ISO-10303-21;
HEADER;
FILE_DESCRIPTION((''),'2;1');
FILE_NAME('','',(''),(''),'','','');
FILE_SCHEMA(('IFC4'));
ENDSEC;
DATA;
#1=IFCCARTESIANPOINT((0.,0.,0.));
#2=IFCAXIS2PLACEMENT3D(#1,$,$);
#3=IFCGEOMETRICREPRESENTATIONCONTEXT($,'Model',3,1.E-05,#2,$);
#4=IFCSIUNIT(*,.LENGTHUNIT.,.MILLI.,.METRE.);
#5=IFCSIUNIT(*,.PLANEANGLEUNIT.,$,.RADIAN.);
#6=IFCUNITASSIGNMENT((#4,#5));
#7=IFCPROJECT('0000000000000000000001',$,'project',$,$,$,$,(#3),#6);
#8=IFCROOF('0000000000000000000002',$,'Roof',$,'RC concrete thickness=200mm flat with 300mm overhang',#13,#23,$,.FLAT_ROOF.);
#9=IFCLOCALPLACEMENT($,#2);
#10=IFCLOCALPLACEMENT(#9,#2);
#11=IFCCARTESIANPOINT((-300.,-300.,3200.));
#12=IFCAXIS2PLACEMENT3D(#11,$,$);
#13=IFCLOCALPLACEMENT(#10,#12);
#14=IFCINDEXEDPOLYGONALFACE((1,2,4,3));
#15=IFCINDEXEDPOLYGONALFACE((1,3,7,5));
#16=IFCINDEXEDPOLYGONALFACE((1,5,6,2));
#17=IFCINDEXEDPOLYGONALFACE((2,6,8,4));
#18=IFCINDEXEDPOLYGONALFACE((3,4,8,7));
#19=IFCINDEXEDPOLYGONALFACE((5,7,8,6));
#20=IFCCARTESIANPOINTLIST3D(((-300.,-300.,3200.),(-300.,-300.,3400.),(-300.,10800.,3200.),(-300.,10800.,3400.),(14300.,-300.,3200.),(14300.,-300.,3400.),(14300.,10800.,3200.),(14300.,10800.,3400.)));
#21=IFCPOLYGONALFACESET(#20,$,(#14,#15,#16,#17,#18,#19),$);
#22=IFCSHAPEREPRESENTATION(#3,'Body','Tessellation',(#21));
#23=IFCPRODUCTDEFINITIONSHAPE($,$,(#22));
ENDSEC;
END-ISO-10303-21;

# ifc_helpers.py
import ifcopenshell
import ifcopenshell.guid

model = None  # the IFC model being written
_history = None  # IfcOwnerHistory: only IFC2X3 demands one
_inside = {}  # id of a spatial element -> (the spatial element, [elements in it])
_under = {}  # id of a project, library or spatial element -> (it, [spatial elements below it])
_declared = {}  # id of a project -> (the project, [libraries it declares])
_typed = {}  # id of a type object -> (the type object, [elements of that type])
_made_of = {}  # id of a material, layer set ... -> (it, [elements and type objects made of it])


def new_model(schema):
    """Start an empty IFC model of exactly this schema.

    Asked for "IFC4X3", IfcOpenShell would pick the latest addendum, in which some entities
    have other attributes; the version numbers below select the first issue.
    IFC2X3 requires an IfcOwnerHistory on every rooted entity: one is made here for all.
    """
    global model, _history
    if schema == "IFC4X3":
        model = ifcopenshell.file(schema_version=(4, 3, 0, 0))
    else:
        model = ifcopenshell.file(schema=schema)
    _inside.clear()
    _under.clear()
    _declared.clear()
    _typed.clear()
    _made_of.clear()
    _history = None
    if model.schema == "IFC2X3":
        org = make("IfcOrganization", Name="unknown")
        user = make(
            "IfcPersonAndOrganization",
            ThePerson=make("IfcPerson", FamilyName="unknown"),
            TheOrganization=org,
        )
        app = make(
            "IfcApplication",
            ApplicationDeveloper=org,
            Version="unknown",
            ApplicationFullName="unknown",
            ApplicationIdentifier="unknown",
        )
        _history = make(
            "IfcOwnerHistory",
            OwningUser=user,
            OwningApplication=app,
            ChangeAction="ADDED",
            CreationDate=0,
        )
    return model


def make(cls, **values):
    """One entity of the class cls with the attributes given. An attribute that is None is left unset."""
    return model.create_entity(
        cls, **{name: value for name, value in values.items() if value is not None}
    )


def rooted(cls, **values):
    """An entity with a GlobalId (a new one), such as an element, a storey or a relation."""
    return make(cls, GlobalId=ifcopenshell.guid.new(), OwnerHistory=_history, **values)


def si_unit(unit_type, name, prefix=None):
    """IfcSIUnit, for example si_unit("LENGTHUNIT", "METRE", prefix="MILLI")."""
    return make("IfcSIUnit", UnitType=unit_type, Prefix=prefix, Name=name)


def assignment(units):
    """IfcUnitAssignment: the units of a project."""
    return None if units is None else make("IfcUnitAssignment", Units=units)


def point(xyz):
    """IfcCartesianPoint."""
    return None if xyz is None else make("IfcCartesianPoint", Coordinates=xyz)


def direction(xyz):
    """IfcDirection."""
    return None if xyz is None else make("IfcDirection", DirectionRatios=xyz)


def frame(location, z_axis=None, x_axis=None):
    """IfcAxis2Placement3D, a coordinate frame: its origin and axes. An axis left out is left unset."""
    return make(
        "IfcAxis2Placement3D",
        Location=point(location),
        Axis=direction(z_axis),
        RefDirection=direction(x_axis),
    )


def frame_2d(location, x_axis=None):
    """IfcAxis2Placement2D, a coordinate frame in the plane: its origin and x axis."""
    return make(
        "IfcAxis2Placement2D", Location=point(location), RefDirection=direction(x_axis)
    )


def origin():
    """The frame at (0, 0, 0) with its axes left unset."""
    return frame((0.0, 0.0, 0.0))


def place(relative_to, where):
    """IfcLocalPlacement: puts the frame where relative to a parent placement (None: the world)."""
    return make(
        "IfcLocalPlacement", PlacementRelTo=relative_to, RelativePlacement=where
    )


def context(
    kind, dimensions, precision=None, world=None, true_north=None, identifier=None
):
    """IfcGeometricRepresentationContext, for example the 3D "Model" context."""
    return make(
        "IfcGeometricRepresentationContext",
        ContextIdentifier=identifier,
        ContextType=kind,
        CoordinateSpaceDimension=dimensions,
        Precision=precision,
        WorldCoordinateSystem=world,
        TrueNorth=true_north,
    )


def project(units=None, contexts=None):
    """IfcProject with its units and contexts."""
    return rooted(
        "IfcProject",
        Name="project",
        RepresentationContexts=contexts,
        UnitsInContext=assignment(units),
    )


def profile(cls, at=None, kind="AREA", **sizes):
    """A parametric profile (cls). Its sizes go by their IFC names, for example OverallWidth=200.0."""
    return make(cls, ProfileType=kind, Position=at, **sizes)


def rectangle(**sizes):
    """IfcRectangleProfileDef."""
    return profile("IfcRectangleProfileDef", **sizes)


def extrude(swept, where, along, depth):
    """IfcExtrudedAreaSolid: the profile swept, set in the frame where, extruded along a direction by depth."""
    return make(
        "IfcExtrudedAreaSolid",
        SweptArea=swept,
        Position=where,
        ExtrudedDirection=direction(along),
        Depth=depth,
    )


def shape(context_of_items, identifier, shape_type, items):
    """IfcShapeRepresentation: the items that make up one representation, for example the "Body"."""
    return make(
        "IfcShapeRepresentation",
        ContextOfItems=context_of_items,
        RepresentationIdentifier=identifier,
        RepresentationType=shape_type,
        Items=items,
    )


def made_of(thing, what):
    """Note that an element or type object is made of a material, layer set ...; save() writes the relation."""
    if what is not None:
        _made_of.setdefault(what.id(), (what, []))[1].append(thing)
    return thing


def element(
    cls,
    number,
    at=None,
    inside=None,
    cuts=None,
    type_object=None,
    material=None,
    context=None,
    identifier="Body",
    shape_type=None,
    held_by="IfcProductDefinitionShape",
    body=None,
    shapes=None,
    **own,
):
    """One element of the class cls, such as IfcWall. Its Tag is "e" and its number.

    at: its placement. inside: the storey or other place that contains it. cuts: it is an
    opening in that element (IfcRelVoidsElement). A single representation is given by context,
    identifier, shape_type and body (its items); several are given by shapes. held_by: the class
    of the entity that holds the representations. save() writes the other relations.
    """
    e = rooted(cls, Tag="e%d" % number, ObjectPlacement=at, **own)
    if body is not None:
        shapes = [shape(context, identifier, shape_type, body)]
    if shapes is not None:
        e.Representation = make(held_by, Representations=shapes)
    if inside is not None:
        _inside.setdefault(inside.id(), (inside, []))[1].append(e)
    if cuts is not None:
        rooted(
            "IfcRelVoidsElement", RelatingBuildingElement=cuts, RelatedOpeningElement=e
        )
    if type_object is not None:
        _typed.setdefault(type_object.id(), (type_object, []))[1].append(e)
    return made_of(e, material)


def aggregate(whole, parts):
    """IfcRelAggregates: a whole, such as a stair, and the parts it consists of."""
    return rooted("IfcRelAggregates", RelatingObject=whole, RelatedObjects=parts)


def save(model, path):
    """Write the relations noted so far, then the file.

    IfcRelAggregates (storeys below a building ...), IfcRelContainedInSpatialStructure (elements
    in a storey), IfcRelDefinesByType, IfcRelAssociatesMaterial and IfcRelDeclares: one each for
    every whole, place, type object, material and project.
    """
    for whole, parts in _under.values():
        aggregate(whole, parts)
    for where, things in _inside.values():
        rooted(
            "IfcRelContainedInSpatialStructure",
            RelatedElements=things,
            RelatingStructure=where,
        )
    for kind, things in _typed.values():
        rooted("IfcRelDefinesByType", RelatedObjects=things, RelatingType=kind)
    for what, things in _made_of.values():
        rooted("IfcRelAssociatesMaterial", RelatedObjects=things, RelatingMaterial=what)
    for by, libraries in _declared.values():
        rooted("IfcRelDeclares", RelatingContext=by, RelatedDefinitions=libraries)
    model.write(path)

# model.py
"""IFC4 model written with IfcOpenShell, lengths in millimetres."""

from ifc_helpers import new_model, si_unit, frame, frame_2d, origin, place, context, project, rectangle, extrude, element, save


model = new_model("IFC4")

# Units and contexts
model_context = context("Model", 3, precision=1e-05, world=origin())
ifc_project = project(units=[si_unit("LENGTHUNIT", "METRE", prefix="MILLI"), si_unit("PLANEANGLEUNIT", "RADIAN")], contexts=[model_context])

# Roof
placement_1 = place(None, origin())
placement_2 = place(placement_1, origin())
roof_placement = place(placement_2, frame((-300.0, -300.0, 3200.0)))
element("IfcRoof", 1, at=roof_placement, Name="Roof", ObjectType="RC concrete thickness=200mm flat with 300mm overhang", PredefinedType="FLAT_ROOF", context=model_context, shape_type="SweptSolid", body=[
    extrude(rectangle(XDim=14600.0, YDim=11100.0, at=frame_2d((7300.0, 5550.0))), frame((-300.0, -300.0, 3200.0)), (0.0, 0.0, 1.0), 200.0),
])

save(model, "model.ifc")
